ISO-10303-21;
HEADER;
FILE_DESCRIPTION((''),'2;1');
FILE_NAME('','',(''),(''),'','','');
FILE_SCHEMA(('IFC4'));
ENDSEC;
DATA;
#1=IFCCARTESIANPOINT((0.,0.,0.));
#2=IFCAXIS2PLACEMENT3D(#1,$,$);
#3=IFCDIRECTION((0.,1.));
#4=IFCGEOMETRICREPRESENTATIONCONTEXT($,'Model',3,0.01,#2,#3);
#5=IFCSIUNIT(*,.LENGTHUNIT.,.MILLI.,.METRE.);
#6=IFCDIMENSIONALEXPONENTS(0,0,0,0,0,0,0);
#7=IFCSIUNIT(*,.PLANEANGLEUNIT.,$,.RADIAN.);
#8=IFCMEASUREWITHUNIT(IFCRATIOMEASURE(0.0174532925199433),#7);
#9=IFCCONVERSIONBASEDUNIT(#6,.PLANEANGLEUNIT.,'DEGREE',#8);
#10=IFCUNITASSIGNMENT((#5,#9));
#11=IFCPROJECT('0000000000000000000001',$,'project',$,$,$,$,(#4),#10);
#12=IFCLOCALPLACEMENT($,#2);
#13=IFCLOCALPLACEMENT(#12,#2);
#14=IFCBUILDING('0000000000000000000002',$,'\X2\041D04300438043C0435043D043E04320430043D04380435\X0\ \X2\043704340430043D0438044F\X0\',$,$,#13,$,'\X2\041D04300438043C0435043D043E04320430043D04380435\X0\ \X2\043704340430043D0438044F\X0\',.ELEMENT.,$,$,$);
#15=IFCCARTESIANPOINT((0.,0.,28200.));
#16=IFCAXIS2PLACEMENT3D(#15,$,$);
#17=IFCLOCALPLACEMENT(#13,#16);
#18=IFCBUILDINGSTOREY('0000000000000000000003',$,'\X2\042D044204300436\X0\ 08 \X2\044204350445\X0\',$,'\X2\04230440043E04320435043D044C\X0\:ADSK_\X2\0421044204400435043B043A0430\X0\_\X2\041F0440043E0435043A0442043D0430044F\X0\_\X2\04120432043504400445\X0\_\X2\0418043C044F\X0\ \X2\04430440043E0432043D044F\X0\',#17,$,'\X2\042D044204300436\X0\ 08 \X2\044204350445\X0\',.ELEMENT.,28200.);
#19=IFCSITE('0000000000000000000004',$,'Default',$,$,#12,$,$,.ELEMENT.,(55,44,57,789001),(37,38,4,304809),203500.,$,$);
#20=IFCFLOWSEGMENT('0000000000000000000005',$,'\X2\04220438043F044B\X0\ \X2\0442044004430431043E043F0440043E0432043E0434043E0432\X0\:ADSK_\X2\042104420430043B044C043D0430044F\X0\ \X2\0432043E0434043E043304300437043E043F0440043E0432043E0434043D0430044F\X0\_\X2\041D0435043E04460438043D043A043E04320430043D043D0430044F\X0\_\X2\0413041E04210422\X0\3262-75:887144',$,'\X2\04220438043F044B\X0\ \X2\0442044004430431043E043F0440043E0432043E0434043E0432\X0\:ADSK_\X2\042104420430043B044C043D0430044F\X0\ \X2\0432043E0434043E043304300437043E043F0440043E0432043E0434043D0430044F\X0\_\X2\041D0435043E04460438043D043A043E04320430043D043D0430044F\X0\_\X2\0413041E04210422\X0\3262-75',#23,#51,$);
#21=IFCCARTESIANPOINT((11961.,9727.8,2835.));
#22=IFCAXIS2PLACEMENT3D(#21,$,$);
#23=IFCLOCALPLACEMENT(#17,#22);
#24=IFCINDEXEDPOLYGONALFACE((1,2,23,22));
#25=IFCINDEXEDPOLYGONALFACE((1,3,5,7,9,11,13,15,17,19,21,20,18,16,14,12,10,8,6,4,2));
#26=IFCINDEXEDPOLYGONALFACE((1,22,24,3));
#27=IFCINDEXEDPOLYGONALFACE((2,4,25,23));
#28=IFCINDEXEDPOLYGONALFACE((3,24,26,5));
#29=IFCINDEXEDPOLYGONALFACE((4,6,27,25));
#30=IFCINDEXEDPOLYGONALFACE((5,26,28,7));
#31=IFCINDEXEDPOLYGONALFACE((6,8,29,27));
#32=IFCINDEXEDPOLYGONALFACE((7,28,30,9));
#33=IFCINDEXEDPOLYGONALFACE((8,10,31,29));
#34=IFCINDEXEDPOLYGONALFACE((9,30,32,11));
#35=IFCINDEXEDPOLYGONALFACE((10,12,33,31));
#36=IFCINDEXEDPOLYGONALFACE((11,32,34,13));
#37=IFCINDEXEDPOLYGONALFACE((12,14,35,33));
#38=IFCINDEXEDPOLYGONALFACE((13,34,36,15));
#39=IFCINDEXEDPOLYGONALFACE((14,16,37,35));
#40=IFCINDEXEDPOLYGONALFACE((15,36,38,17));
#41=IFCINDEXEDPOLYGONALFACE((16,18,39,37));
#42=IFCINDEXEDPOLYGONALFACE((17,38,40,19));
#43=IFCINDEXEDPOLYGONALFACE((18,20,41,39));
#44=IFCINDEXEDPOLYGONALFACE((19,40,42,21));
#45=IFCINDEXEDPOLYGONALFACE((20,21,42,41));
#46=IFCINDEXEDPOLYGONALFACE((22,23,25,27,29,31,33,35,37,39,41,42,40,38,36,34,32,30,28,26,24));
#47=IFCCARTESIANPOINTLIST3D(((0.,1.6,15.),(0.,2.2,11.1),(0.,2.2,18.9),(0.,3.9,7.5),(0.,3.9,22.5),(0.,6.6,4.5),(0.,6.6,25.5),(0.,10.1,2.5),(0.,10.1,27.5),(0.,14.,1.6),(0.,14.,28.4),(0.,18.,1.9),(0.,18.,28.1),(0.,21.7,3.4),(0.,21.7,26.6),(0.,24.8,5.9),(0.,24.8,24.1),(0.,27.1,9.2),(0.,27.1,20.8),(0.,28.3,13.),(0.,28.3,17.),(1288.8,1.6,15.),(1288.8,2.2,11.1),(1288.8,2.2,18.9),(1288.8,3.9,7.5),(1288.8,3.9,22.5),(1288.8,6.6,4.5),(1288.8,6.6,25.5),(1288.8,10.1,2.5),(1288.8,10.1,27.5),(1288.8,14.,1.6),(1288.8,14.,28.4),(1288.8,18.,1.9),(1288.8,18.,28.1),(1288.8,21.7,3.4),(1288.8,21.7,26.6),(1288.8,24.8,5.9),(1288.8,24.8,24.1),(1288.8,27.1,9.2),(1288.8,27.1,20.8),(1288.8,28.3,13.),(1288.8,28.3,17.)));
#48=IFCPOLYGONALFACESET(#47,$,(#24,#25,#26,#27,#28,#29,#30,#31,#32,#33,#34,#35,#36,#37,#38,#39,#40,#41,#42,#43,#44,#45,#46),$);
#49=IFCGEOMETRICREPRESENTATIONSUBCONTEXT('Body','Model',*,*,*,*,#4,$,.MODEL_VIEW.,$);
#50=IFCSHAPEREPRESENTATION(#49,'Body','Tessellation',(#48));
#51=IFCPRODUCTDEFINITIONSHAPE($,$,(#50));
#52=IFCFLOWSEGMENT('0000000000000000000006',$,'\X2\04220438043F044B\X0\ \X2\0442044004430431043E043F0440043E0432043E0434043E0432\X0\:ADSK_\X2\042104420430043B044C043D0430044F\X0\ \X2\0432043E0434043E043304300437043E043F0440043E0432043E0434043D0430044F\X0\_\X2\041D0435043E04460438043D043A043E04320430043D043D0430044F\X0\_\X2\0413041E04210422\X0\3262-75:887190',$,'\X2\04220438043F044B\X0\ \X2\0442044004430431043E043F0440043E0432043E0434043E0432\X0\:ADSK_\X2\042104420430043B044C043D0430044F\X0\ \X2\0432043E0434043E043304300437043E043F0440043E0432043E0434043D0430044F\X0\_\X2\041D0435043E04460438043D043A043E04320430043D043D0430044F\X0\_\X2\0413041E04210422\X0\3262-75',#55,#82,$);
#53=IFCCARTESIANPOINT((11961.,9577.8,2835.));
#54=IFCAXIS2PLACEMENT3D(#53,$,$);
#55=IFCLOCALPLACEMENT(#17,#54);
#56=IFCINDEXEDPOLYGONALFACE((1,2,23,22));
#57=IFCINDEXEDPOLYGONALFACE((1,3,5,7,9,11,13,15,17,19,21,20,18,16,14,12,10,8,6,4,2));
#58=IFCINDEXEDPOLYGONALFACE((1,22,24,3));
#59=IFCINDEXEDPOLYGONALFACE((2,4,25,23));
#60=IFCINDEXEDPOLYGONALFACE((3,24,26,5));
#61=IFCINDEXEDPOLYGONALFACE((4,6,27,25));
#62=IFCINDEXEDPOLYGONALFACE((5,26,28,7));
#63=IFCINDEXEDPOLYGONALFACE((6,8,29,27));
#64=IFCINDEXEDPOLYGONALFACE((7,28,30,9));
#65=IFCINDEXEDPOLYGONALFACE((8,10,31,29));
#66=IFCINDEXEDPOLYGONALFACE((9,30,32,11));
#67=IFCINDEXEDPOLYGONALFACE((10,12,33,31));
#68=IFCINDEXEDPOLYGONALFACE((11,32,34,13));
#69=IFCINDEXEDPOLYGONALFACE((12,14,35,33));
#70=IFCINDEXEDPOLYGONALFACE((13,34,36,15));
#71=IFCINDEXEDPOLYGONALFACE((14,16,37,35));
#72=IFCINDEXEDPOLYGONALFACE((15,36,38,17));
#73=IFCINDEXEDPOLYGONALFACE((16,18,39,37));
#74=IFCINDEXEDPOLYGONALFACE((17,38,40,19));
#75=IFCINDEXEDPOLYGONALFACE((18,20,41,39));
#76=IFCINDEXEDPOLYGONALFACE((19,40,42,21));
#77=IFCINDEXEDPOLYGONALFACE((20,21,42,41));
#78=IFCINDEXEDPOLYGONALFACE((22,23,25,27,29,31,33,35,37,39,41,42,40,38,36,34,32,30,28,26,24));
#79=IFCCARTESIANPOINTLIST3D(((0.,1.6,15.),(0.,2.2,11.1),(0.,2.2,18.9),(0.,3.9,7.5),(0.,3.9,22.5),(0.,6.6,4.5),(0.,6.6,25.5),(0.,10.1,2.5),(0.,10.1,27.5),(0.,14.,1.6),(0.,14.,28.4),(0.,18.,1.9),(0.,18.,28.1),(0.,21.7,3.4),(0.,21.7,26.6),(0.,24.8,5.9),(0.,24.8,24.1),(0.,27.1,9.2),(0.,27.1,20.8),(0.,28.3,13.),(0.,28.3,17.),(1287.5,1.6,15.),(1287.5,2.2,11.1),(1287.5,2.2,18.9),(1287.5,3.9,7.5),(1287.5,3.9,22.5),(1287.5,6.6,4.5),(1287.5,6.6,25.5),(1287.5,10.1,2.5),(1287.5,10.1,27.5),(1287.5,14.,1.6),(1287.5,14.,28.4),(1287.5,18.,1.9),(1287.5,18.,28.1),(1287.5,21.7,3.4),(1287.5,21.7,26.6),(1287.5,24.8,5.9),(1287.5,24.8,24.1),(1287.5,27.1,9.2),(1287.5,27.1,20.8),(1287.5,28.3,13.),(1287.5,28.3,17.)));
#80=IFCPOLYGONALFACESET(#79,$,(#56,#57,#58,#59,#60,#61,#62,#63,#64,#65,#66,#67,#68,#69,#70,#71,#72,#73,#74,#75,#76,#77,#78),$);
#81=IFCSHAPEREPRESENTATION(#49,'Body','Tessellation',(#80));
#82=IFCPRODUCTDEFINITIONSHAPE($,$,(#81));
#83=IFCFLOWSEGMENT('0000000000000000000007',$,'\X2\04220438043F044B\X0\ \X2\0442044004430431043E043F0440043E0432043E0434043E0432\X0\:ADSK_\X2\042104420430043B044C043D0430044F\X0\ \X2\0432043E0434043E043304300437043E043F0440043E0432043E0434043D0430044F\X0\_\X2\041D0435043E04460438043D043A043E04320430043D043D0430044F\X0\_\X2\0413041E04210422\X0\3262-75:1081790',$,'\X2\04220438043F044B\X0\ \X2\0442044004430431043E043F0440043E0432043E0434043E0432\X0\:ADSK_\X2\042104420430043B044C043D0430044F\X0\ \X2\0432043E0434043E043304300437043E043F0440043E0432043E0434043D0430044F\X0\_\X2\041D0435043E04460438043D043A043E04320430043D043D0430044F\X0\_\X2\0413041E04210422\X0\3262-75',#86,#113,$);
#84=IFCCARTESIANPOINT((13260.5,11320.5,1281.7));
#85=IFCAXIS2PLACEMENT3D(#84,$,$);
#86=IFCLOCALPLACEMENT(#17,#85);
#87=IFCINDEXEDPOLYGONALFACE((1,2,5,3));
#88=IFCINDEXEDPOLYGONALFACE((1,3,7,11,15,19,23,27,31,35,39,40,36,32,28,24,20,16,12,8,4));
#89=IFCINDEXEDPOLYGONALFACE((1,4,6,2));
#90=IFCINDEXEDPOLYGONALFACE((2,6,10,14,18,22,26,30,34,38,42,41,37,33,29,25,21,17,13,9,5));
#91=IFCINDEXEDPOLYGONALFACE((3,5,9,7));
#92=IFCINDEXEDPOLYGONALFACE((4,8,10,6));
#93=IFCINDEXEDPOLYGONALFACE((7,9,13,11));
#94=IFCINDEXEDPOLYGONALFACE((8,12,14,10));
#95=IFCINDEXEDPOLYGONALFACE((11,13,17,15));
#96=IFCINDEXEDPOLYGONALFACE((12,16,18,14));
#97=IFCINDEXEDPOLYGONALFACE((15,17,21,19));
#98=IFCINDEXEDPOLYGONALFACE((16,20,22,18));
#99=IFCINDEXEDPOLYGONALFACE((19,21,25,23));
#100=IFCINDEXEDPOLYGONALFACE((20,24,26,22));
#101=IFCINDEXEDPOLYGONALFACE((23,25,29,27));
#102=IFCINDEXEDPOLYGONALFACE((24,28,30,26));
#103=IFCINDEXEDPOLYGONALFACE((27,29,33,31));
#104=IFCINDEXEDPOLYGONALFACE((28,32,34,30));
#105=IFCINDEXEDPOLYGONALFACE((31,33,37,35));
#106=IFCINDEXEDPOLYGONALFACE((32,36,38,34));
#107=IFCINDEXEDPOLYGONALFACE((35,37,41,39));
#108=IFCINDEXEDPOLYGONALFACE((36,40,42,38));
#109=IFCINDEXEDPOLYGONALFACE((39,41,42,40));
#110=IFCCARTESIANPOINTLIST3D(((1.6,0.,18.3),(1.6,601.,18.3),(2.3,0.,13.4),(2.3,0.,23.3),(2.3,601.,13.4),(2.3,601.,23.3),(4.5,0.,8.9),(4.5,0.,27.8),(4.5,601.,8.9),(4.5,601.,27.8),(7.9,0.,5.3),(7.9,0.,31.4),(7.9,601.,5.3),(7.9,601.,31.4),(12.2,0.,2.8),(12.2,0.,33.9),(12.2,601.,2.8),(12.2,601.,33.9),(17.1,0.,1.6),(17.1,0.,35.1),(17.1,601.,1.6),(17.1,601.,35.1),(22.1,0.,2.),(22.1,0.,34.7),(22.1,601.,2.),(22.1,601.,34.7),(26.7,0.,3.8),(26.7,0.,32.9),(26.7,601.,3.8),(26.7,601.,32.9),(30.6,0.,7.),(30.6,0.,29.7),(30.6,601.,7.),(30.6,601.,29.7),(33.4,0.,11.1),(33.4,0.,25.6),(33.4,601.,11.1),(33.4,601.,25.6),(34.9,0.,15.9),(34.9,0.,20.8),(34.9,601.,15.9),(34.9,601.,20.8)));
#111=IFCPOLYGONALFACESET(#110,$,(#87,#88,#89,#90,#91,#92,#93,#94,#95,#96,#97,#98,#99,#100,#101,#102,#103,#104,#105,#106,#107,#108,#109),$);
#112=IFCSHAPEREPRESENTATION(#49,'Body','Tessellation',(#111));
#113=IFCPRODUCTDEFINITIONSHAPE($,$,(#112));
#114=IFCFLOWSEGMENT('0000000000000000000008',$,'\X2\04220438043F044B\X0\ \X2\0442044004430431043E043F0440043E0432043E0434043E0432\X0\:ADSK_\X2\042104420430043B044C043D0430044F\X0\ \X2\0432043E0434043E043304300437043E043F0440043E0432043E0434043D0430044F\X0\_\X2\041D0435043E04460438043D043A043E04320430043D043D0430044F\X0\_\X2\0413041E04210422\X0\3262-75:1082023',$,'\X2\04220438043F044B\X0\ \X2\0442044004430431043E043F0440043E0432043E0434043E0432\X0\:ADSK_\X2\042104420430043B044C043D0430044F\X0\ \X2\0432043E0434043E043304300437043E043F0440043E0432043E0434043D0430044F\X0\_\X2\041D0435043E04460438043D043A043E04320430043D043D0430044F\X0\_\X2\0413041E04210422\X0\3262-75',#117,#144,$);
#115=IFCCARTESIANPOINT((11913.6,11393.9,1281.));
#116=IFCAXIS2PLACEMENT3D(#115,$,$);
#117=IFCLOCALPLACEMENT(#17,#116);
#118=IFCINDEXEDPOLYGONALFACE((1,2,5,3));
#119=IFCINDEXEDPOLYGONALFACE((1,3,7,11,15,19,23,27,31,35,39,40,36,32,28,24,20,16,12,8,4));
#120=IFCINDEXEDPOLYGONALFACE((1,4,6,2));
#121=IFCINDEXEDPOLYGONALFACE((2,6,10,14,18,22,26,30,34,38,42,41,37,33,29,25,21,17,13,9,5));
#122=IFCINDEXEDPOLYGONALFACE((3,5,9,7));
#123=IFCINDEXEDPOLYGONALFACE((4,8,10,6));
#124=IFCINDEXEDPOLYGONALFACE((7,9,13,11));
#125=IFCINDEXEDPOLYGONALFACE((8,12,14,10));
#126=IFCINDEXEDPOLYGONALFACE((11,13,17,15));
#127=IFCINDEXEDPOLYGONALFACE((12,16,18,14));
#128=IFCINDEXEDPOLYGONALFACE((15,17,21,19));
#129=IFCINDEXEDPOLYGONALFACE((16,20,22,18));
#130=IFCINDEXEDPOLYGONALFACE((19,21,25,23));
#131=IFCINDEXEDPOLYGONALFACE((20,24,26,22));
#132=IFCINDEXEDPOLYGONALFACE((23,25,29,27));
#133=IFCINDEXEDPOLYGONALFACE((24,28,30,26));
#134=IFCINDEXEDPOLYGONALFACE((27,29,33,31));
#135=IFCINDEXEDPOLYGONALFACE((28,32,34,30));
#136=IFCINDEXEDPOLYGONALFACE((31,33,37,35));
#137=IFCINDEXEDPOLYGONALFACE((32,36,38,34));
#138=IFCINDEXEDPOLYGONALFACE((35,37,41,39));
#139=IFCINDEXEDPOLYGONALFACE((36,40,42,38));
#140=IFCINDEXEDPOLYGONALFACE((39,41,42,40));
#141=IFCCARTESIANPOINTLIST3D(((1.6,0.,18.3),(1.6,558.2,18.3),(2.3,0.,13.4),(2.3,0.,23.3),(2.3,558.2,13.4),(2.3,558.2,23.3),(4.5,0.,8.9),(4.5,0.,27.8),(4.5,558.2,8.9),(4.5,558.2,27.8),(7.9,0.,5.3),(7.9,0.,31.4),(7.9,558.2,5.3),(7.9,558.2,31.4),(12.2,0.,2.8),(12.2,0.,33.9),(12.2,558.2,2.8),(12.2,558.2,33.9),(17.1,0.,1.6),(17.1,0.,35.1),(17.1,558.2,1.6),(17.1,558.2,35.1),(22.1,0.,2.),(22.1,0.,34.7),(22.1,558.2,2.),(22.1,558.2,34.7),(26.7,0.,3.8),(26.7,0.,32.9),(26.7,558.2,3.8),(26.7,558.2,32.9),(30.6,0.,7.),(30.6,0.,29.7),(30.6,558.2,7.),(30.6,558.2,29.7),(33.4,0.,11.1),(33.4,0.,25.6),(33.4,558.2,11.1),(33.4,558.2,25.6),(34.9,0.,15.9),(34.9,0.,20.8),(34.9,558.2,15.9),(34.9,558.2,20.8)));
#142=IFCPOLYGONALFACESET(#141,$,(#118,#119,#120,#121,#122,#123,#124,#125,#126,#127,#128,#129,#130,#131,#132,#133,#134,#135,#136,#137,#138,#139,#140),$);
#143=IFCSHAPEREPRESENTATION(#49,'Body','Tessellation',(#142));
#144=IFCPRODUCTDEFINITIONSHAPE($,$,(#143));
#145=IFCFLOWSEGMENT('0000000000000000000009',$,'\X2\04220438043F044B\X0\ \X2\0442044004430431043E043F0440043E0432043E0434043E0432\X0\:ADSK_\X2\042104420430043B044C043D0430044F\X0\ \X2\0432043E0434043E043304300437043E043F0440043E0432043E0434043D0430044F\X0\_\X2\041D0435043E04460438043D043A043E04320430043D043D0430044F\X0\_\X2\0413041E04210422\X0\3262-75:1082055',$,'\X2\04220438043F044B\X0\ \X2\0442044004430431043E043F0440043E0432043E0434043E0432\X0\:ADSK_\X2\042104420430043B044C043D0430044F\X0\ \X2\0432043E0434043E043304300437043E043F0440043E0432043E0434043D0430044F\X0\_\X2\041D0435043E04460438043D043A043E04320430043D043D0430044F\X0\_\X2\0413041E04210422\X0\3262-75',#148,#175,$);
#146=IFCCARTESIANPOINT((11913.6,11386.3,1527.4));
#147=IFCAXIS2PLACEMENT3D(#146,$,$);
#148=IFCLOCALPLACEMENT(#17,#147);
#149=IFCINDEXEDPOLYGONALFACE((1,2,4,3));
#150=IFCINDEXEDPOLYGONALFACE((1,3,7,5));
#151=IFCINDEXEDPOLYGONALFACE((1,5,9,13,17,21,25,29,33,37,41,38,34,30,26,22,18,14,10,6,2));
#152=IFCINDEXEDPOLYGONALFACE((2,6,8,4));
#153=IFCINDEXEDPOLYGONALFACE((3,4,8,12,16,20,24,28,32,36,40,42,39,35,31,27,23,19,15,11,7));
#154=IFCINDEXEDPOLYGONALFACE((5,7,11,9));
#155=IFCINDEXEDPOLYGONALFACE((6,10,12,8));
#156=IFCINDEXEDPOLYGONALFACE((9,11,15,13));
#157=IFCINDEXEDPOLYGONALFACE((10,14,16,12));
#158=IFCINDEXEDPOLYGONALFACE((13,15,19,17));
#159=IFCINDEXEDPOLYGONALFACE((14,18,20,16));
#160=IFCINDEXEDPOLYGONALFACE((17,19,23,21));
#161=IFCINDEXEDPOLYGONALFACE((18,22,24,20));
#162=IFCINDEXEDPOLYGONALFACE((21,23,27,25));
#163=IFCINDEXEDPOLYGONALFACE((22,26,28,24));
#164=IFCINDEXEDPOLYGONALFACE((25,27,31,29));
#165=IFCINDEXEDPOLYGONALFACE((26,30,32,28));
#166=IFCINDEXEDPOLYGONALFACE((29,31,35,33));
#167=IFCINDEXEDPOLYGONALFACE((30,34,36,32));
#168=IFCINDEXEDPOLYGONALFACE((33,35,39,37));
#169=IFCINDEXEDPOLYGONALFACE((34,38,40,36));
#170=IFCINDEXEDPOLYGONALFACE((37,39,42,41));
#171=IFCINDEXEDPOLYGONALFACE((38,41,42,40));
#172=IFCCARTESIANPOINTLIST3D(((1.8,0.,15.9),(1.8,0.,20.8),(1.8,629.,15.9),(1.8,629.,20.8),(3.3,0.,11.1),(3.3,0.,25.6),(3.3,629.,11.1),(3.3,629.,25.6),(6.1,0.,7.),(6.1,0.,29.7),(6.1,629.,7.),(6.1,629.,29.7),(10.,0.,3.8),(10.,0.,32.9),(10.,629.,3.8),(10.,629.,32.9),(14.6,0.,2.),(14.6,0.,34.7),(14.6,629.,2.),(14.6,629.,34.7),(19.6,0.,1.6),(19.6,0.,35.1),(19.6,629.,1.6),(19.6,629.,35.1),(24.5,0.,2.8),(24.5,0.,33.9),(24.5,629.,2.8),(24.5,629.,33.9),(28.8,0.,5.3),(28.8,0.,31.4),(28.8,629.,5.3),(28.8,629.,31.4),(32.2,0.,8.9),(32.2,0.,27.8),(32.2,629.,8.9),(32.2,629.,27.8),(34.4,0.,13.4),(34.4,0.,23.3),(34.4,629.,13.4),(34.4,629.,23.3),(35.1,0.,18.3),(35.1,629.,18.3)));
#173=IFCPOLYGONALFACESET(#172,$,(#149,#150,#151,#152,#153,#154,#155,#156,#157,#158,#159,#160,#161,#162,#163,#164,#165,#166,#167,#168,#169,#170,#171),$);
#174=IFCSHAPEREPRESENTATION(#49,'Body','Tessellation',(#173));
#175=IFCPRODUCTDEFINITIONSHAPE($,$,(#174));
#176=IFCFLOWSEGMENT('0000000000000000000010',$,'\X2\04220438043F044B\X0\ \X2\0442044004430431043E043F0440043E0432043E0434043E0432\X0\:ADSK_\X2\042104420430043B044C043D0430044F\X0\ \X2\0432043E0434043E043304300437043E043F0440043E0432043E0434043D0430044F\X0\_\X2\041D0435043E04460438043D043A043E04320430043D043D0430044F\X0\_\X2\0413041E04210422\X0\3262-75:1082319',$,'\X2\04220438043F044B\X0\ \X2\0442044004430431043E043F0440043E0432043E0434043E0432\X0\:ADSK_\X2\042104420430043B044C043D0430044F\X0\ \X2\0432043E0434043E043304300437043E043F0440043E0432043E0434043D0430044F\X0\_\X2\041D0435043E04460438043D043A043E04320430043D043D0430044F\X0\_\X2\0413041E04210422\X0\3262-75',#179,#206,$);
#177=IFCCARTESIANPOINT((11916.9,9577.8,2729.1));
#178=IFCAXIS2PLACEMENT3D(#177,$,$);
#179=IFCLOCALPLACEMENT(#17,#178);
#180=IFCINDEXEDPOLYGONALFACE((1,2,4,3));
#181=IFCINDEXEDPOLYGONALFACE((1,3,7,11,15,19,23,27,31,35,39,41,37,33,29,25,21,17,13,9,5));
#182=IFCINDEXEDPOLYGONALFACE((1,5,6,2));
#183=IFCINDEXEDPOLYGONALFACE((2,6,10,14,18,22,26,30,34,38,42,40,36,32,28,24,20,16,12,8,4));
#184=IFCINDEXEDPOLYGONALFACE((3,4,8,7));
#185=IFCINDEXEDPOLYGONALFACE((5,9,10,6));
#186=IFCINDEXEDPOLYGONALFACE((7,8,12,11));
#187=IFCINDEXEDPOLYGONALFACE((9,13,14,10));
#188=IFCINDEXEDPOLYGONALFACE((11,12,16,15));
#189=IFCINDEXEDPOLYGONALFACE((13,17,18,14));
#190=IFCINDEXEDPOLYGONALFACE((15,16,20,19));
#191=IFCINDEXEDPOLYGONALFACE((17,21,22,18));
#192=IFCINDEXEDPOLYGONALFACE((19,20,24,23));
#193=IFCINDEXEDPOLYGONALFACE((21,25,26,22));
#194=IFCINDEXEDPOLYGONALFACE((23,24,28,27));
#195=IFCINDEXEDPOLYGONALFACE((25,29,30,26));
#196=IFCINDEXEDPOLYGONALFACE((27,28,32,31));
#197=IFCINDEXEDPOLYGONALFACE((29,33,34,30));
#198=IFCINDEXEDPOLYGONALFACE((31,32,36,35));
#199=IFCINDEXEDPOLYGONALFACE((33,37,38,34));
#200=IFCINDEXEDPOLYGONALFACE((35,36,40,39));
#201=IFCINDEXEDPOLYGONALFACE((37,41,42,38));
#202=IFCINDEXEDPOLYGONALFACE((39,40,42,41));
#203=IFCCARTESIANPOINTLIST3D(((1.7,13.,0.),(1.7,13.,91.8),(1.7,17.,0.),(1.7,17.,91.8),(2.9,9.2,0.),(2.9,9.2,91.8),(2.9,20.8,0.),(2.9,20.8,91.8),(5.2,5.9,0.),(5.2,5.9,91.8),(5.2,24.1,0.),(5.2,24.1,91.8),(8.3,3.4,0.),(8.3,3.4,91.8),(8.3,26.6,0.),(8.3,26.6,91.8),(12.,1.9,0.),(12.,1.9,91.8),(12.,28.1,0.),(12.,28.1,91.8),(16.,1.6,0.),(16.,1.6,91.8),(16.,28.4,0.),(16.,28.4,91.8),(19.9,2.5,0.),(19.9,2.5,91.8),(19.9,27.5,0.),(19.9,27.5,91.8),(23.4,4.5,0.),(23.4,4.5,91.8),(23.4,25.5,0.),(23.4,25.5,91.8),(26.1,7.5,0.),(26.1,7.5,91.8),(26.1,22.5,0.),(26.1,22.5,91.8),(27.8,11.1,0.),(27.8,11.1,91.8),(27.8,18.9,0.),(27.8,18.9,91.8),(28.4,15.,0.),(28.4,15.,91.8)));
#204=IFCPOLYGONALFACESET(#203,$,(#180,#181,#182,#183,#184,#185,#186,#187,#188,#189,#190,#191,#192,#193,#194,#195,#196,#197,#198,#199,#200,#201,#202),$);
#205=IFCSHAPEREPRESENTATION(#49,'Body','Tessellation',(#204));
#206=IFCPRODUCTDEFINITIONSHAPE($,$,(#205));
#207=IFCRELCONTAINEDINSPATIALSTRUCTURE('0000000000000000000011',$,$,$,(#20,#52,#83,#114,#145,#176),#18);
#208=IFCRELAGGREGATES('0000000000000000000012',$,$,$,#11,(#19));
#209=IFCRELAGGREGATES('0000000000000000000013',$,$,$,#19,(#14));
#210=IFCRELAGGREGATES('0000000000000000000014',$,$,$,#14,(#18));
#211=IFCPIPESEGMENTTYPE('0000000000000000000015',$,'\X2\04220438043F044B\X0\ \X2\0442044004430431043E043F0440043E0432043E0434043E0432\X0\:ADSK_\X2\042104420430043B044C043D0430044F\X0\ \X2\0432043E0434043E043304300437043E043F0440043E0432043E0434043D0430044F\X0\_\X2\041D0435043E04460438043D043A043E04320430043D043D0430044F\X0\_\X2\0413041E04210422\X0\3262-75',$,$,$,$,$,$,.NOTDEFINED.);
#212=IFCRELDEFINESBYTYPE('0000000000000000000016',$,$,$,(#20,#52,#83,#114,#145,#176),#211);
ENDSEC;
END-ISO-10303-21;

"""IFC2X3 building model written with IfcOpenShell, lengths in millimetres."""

from ifc_helpers import new_model, entity, si_unit, converted_unit, direction, frame, origin, origin_2d_with_axis, place, context, subcontext, project, spatial, circle, extrude, type_object, element, save


model = new_model("IFC2X3")

# Units and contexts
model_context = context("Model", 3, precision=0.01, world=origin(), true_north=direction((0.0, 1.0)))
body_context = subcontext(model_context, "Body", "Model", "MODEL_VIEW")
ifc_project = project(units=[si_unit("LENGTHUNIT", "METRE", prefix="MILLI"), converted_unit("PLANEANGLEUNIT", "DEGREE", entity("IfcRatioMeasure", 0.0174532925199433), si_unit("PLANEANGLEUNIT", "RADIAN"), dimensions=[0, 0, 0, 0, 0, 0, 0])], contexts=[model_context])

# Site, building, storey
site_placement = place(None, origin())
site = spatial("IfcSite", under=ifc_project, at=site_placement, Name="Default", CompositionType="ELEMENT", RefLatitude=(55, 44, 57, 789001), RefLongitude=(37, 38, 4, 304809), RefElevation=203500.0)
building_placement = place(site_placement, origin())
building = spatial("IfcBuilding", under=site, at=building_placement, Name="Наименование здания", LongName="Наименование здания", CompositionType="ELEMENT")
storey_placement = place(building_placement, frame((0.0, 0.0, 28200.0)))
storey = spatial("IfcBuildingStorey", under=building, at=storey_placement, Name="Этаж 08 тех", ObjectType="Уровень:ADSK_Стрелка_Проектная_Вверх_Имя уровня", LongName="Этаж 08 тех", CompositionType="ELEMENT", Elevation=28200.0)

# Flow segments
pipe_segment_type = type_object("IfcPipeSegmentType", Name="Типы трубопроводов:ADSK_Стальная водогазопроводная_Неоцинкованная_ГОСТ3262-75", PredefinedType="NOTDEFINED")
flow_segment_1_placement = place(storey_placement, frame((11961.0, 9727.8, 2835.0)))
element("IfcFlowSegment", 1, at=flow_segment_1_placement, inside=storey, type_object=pipe_segment_type, Name="Типы трубопроводов:ADSK_Стальная водогазопроводная_Неоцинкованная_ГОСТ3262-75:887144", ObjectType="Типы трубопроводов:ADSK_Стальная водогазопроводная_Неоцинкованная_ГОСТ3262-75", context=body_context, shape_type="SweptSolid", body=[
    extrude(circle(Radius=13.4, at=origin_2d_with_axis()), frame((0.0, 15.0, 15.0), z_axis=(1.0, 0.0, 0.0), x_axis=(0.0, -1.0, 0.0)), (0.0, 0.0, 1.0), 1288.8),
])
flow_segment_2_placement = place(storey_placement, frame((11961.0, 9577.8, 2835.0)))
element("IfcFlowSegment", 2, at=flow_segment_2_placement, inside=storey, type_object=pipe_segment_type, Name="Типы трубопроводов:ADSK_Стальная водогазопроводная_Неоцинкованная_ГОСТ3262-75:887190", ObjectType="Типы трубопроводов:ADSK_Стальная водогазопроводная_Неоцинкованная_ГОСТ3262-75", context=body_context, shape_type="SweptSolid", body=[
    extrude(circle(Radius=13.4, at=origin_2d_with_axis()), frame((0.0, 15.0, 15.0), z_axis=(1.0, 0.0, 0.0), x_axis=(0.0, -1.0, 0.0)), (0.0, 0.0, 1.0), 1287.5),
])
flow_segment_3_placement = place(storey_placement, frame((13260.5, 11320.5, 1281.7)))
element("IfcFlowSegment", 3, at=flow_segment_3_placement, inside=storey, type_object=pipe_segment_type, Name="Типы трубопроводов:ADSK_Стальная водогазопроводная_Неоцинкованная_ГОСТ3262-75:1081790", ObjectType="Типы трубопроводов:ADSK_Стальная водогазопроводная_Неоцинкованная_ГОСТ3262-75", context=body_context, shape_type="SweptSolid", body=[
    extrude(circle(Radius=16.8, at=origin_2d_with_axis()), frame((18.4, 0.0, 18.4), z_axis=(0.0, 1.0, 0.0), x_axis=(-1.0, 0.0, 0.0)), (0.0, 0.0, 1.0), 601.0),
])
flow_segment_4_placement = place(storey_placement, frame((11913.6, 11393.9, 1281.0)))
element("IfcFlowSegment", 4, at=flow_segment_4_placement, inside=storey, type_object=pipe_segment_type, Name="Типы трубопроводов:ADSK_Стальная водогазопроводная_Неоцинкованная_ГОСТ3262-75:1082023", ObjectType="Типы трубопроводов:ADSK_Стальная водогазопроводная_Неоцинкованная_ГОСТ3262-75", context=body_context, shape_type="SweptSolid", body=[
    extrude(circle(Radius=16.8, at=origin_2d_with_axis()), frame((18.4, 0.0, 18.4), z_axis=(0.0, 1.0, 0.0), x_axis=(-1.0, 0.0, 0.0)), (0.0, 0.0, 1.0), 558.2),
])
flow_segment_5_placement = place(storey_placement, frame((11913.6, 11386.3, 1527.4)))
element("IfcFlowSegment", 5, at=flow_segment_5_placement, inside=storey, type_object=pipe_segment_type, Name="Типы трубопроводов:ADSK_Стальная водогазопроводная_Неоцинкованная_ГОСТ3262-75:1082055", ObjectType="Типы трубопроводов:ADSK_Стальная водогазопроводная_Неоцинкованная_ГОСТ3262-75", context=body_context, shape_type="SweptSolid", body=[
    extrude(circle(Radius=16.8, at=origin_2d_with_axis()), frame((18.4, 0.0, 18.4), z_axis=(0.0, 1.0, 0.0), x_axis=(1.0, 0.0, 0.0)), (0.0, 0.0, 1.0), 629.0),
])
flow_segment_6_placement = place(storey_placement, frame((11916.9, 9577.8, 2729.1)))
element("IfcFlowSegment", 6, at=flow_segment_6_placement, inside=storey, type_object=pipe_segment_type, Name="Типы трубопроводов:ADSK_Стальная водогазопроводная_Неоцинкованная_ГОСТ3262-75:1082319", ObjectType="Типы трубопроводов:ADSK_Стальная водогазопроводная_Неоцинкованная_ГОСТ3262-75", context=body_context, shape_type="SweptSolid", body=[
    extrude(circle(Radius=13.4, at=origin_2d_with_axis()), frame((15.0, 15.0, 0.0)), (0.0, 0.0, 1.0), 91.8),
])

save(model, "model.ifc")
